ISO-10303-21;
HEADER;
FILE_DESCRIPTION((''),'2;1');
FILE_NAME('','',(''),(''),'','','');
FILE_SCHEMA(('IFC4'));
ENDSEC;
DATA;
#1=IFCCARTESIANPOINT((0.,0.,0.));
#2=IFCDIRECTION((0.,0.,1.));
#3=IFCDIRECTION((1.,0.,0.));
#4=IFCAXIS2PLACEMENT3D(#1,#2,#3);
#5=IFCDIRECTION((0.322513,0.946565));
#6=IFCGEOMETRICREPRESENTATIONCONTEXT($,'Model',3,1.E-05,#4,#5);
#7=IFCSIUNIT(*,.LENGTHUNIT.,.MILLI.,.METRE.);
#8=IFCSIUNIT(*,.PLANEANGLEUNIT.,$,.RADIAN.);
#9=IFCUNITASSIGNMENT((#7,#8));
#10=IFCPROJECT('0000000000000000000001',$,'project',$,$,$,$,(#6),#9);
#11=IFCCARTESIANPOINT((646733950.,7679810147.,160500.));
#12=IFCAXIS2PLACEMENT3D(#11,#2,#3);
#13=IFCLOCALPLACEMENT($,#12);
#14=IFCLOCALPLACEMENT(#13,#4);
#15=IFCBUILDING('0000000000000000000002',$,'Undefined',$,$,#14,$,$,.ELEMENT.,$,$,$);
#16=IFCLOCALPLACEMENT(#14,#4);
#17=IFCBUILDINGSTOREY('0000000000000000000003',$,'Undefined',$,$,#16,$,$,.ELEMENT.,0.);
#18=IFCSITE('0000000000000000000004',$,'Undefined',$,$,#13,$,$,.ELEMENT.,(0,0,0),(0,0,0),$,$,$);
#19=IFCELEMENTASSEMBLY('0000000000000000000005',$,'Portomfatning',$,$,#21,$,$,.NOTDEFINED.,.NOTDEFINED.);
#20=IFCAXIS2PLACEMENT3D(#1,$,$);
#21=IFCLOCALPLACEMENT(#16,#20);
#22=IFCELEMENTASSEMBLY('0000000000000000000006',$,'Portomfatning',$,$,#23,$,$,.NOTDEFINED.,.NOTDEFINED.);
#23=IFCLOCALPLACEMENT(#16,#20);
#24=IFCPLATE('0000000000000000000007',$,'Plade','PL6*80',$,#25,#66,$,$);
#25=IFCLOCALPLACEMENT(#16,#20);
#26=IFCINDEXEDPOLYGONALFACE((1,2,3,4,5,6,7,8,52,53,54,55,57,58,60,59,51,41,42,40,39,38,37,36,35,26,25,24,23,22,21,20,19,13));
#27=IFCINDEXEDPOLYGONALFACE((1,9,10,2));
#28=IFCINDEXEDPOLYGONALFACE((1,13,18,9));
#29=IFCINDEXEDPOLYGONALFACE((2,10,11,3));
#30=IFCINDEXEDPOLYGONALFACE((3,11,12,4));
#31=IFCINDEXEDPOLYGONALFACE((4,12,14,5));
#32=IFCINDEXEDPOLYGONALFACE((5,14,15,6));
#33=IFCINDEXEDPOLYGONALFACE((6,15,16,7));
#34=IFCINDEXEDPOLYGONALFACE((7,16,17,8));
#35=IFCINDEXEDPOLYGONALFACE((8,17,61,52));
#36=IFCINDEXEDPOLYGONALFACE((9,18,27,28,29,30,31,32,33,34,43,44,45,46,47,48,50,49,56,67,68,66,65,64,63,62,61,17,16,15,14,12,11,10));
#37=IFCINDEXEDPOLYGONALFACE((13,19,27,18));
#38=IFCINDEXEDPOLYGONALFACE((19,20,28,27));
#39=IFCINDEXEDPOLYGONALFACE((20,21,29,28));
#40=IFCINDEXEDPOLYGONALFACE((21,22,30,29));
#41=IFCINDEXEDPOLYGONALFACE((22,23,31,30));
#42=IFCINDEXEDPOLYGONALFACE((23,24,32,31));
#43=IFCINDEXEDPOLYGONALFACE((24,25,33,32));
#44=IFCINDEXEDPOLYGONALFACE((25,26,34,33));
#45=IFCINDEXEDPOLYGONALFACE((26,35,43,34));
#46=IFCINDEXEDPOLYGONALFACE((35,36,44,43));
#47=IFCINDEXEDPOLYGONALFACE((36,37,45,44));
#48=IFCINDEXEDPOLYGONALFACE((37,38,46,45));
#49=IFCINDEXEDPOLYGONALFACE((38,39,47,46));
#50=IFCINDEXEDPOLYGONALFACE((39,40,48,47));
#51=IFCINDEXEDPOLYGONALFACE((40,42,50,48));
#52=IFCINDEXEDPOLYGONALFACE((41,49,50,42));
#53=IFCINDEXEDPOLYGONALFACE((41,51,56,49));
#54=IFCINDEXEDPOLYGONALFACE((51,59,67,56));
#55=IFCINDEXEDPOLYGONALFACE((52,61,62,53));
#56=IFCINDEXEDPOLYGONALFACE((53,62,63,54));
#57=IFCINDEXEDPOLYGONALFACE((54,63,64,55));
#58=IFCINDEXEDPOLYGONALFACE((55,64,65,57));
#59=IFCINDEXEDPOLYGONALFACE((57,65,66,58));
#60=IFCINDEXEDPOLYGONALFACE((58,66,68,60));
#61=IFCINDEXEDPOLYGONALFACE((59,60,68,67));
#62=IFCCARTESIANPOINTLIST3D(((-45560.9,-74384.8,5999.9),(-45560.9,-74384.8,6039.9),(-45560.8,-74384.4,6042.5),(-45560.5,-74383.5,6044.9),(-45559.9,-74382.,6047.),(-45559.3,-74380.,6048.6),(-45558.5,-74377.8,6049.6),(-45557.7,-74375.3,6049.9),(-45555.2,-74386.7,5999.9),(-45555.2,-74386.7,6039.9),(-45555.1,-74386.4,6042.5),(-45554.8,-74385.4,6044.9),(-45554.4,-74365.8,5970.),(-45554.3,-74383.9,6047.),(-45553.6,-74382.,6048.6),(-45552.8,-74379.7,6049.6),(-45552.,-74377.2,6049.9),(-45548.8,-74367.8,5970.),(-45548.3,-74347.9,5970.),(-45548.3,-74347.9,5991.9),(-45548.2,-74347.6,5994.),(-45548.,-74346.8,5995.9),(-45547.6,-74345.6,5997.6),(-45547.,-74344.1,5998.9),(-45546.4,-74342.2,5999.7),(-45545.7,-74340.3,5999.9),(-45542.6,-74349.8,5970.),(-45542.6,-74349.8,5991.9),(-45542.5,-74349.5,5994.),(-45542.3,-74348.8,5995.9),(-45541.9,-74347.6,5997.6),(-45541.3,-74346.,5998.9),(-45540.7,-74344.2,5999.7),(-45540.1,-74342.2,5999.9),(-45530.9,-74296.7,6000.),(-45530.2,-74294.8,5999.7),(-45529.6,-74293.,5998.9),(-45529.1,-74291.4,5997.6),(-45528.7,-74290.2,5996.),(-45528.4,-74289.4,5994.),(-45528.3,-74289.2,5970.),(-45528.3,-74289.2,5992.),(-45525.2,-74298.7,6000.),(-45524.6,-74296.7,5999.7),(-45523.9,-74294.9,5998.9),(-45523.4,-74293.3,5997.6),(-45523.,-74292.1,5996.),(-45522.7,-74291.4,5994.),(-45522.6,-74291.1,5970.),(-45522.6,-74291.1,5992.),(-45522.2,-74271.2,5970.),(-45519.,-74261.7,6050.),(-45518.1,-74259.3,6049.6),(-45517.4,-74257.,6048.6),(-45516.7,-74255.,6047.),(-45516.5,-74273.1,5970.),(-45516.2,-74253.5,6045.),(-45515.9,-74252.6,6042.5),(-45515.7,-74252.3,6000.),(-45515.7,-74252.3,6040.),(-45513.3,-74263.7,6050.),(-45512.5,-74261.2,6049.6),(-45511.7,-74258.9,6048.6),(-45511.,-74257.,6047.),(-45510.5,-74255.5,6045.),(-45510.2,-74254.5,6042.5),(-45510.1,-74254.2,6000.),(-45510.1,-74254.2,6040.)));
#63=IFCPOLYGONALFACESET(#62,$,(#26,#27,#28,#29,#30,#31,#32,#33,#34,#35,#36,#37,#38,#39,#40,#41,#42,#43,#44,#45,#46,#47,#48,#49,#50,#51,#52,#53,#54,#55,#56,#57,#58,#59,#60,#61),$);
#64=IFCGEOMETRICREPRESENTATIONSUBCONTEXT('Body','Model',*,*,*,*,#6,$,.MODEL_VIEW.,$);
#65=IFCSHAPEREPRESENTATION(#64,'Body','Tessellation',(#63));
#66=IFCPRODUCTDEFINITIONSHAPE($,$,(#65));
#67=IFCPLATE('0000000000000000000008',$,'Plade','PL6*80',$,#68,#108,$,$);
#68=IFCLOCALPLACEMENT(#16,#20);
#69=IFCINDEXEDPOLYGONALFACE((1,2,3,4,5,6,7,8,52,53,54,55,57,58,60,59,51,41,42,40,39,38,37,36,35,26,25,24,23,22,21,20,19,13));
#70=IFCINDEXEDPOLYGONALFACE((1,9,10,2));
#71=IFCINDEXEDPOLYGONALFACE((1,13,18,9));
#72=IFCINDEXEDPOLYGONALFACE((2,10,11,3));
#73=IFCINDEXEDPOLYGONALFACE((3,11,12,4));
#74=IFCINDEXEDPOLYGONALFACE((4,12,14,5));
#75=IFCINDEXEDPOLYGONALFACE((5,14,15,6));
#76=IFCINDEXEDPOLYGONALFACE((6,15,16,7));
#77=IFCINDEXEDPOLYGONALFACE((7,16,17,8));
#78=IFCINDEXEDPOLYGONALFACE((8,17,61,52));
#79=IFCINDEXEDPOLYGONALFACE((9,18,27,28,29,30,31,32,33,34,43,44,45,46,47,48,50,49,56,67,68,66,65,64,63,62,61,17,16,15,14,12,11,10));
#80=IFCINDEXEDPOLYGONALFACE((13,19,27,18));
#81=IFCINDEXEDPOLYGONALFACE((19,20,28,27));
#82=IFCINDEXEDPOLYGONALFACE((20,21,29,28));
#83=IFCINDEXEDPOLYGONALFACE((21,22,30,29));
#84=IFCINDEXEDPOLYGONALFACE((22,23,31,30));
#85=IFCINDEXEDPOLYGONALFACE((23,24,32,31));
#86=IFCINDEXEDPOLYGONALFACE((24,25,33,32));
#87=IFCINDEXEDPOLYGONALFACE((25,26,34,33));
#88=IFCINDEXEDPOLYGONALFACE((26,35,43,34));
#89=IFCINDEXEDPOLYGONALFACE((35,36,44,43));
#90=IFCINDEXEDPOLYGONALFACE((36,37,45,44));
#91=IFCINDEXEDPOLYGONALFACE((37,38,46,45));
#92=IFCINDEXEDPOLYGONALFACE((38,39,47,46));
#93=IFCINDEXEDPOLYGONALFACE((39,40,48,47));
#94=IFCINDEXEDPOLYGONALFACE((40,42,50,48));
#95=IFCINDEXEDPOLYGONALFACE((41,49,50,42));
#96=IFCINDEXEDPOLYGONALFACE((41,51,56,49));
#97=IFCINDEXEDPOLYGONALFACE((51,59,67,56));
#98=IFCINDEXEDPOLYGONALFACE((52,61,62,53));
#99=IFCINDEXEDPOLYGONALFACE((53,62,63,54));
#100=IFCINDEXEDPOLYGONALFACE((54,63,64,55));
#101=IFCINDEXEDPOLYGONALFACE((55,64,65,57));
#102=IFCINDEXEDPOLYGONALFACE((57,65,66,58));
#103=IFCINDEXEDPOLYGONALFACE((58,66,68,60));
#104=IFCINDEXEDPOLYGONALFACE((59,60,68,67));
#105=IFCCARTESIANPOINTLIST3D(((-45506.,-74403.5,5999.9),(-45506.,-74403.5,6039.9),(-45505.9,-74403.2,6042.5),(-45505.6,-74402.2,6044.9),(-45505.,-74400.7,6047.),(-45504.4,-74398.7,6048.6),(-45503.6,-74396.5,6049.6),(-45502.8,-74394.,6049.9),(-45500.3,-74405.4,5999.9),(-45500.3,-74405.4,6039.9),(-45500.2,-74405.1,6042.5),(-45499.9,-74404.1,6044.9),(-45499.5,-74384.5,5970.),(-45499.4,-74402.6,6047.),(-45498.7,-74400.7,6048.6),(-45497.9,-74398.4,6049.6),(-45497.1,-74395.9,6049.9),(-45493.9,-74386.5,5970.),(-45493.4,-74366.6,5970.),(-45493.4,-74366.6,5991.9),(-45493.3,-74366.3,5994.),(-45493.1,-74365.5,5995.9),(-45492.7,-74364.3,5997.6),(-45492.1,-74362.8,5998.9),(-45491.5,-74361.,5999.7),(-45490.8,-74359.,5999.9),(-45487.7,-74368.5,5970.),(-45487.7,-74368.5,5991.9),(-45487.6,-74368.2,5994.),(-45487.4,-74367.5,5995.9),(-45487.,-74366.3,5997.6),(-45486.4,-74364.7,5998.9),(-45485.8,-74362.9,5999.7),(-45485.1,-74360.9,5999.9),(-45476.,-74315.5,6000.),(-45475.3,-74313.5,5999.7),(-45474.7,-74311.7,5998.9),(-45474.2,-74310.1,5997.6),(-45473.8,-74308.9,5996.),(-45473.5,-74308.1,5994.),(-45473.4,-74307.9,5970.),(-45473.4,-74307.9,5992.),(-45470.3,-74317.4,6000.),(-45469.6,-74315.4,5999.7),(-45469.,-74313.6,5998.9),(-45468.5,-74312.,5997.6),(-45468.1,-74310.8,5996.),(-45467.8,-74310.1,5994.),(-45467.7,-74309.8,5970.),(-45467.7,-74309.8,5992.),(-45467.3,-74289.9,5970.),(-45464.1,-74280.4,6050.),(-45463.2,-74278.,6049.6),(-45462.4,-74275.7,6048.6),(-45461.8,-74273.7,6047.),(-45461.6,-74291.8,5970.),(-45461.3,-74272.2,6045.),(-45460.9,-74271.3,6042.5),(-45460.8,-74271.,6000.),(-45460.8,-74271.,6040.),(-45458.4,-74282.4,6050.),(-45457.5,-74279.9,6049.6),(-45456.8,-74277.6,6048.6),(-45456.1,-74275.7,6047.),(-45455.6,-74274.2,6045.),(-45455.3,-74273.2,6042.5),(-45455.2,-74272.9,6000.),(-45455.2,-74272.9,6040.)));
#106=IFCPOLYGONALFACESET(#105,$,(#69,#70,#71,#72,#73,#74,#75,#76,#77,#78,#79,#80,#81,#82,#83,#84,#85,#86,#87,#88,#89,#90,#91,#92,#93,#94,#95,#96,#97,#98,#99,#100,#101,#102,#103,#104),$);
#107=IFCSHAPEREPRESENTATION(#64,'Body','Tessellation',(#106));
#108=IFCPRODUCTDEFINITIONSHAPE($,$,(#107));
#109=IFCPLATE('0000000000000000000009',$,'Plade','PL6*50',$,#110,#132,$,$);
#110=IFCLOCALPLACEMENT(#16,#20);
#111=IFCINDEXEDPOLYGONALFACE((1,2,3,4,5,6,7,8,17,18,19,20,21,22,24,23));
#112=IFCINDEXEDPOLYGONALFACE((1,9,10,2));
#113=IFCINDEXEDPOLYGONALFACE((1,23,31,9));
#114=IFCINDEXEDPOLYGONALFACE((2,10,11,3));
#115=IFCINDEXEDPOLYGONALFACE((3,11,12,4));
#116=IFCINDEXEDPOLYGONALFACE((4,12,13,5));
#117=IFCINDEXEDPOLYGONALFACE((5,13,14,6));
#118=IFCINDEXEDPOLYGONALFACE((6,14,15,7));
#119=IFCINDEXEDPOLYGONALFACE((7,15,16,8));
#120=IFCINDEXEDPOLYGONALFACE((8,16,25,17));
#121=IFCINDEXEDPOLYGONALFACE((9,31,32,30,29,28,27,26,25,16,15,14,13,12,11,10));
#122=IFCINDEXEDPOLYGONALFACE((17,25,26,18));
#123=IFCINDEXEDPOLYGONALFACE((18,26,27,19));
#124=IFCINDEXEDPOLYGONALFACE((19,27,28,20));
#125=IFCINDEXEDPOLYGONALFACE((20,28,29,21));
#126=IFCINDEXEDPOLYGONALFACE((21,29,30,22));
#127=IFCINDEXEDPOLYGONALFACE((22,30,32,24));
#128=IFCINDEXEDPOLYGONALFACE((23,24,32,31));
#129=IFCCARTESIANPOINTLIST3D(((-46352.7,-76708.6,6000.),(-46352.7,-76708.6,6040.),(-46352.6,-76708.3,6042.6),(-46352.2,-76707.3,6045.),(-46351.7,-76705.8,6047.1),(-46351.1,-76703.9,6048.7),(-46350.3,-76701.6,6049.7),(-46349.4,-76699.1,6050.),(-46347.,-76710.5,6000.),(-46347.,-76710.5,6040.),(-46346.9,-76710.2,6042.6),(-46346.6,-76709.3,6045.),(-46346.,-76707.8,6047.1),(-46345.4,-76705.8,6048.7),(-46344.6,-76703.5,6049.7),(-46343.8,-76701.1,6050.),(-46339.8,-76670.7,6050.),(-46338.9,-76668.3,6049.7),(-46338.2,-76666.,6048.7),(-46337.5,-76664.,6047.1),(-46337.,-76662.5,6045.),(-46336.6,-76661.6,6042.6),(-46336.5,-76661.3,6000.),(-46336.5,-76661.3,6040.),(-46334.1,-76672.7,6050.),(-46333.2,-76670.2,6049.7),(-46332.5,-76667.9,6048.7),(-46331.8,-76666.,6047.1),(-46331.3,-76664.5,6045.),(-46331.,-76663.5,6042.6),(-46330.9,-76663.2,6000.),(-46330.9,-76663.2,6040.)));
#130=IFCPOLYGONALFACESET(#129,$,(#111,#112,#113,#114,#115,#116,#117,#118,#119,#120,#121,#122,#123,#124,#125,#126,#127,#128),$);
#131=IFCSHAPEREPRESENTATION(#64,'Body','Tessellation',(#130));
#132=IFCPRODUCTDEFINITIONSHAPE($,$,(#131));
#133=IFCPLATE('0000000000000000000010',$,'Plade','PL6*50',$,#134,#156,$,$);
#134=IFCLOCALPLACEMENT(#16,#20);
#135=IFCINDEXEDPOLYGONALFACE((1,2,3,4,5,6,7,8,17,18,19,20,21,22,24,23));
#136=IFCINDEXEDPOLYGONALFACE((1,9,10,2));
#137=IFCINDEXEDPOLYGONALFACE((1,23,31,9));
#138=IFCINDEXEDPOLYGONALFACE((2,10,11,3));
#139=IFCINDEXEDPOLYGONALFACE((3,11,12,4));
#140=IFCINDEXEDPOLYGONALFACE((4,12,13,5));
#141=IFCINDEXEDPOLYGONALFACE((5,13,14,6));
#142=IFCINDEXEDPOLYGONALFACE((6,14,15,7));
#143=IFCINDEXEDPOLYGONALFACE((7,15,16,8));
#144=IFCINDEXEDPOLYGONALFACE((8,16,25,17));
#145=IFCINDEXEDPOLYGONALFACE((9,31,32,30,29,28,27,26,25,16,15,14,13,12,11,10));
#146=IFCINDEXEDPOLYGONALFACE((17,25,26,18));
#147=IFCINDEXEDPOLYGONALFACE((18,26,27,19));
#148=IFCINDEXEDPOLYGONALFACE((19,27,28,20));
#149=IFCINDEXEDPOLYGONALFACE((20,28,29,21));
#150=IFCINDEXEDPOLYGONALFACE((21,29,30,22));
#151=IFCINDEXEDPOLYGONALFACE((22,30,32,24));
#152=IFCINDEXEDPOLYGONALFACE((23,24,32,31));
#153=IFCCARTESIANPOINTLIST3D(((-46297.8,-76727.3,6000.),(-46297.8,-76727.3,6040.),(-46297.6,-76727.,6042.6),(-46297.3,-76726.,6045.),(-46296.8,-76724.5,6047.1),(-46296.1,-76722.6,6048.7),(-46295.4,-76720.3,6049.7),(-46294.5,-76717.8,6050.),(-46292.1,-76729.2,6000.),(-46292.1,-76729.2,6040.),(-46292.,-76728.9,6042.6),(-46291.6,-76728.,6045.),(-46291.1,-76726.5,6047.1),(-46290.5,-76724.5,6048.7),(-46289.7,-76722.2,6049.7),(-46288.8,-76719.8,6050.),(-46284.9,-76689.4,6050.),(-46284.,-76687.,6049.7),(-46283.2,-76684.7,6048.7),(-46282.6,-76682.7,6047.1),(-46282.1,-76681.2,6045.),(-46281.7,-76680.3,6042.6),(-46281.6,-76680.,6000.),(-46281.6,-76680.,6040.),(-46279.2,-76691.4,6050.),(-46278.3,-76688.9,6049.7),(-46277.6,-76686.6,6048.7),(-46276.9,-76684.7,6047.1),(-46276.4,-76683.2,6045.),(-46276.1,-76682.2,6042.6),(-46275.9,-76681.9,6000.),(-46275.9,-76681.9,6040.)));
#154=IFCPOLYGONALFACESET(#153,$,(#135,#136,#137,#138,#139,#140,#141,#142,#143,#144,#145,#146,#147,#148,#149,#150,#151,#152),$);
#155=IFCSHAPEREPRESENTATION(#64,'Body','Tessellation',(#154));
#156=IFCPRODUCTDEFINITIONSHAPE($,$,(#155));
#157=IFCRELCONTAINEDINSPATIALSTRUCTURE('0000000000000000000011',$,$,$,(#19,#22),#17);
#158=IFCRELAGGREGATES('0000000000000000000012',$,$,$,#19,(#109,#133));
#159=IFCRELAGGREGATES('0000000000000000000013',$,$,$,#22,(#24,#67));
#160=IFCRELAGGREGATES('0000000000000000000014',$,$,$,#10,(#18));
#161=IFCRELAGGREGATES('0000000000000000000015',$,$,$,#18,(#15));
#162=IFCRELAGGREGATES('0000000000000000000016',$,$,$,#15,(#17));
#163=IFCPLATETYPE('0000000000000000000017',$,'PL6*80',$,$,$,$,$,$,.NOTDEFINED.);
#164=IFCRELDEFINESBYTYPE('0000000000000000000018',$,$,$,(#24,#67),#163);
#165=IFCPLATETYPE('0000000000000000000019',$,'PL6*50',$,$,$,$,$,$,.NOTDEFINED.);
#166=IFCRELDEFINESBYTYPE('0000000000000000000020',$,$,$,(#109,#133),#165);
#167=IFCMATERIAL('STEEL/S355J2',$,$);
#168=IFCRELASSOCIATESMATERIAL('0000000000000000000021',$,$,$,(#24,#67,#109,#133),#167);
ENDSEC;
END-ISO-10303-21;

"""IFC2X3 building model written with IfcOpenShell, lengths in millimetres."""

from ifc_helpers import new_model, si_unit, direction, frame, frame_2d, origin_with_axes, place, context, subcontext, project, spatial, polyline, circle_curve, parameter, trimmed, segment, composite_curve, outline, extrude, material, type_object, element, aggregate, save


model = new_model("IFC2X3")

# Units and contexts
model_context = context("Model", 3, precision=1e-05, world=origin_with_axes(), true_north=direction((0.322513, 0.946565)))
body_context = subcontext(model_context, "Body", "Model", "MODEL_VIEW")
ifc_project = project(units=[si_unit("LENGTHUNIT", "METRE", prefix="MILLI"), si_unit("PLANEANGLEUNIT", "RADIAN")], contexts=[model_context])

# Site, building, storey
site_placement = place(None, frame((646733950.0, 7679810147.0, 160500.0), z_axis=(0.0, 0.0, 1.0), x_axis=(1.0, 0.0, 0.0)))
site = spatial("IfcSite", under=ifc_project, at=site_placement, Name="Undefined", CompositionType="ELEMENT", RefLatitude=(0, 0, 0), RefLongitude=(0, 0, 0))
building_placement = place(site_placement, origin_with_axes())
building = spatial("IfcBuilding", under=site, at=building_placement, Name="Undefined", CompositionType="ELEMENT")
storey_placement = place(building_placement, origin_with_axes())
storey = spatial("IfcBuildingStorey", under=building, at=storey_placement, Name="Undefined", CompositionType="ELEMENT", Elevation=0.0)

# Element assembly
assembly_1_placement = place(storey_placement, origin_with_axes())
assembly_1 = element("IfcElementAssembly", 1, at=assembly_1_placement, inside=storey, Name="Portomfatning", AssemblyPlace="NOTDEFINED", PredefinedType="NOTDEFINED")

# Shared definitions
ifc_material_1 = material(Name="STEEL/S355J2")

# Element assembly
assembly_2_placement = place(storey_placement, origin_with_axes())
assembly_2 = element("IfcElementAssembly", 2, at=assembly_2_placement, inside=storey, Name="Portomfatning", AssemblyPlace="NOTDEFINED", PredefinedType="NOTDEFINED")

# Plates
plate_type_1 = type_object("IfcPlateType", Name="PL6*80", PredefinedType="NOTDEFINED")
plate_1_placement = place(assembly_2_placement, frame((-45558.1, -74385.7, 6049.9), z_axis=(0.946565, -0.322513, 0.0), x_axis=(0.0, 0.0, -1.0)))
plate_1 = element("IfcPlate", 3, at=plate_1_placement, type_object=plate_type_1, material=ifc_material_1, Name="Plade", Description="PL6*80", context=body_context, shape_type="SweptSolid", body=[
    extrude(outline(composite_curve([segment(trimmed(circle_curve(frame_2d((10.0, 10.0), x_axis=(-1.0, -0.000007)), 10.0), [parameter(0.0)], [parameter(1.570789)], True, "PARAMETER"), True, "CONTINUOUS"), segment(polyline([(10.0, 0.0), (50.0, 0.0), (80.0, 20.0), (80.0, 39.0), (58.0, 39.0)]), True, "CONTINUOUS"), segment(trimmed(circle_curve(frame_2d((58.0, 47.0), x_axis=(0.000062, -1.0)), 8.0), [parameter(0.0)], [parameter(4.712337)], False, "PARAMETER"), True, "CONTINUOUS"), segment(polyline([(50.0, 47.0), (50.0, 93.0)]), True, "CONTINUOUS"), segment(trimmed(circle_curve(frame_2d((58.0, 93.0), x_axis=(-1.0, -0.00001)), 8.0), [parameter(0.0)], [parameter(4.712441)], False, "PARAMETER"), True, "CONTINUOUS"), segment(polyline([(58.0, 101.0), (80.0, 101.0), (80.0, 120.0), (50.0, 140.0), (10.0, 140.0)]), True, "CONTINUOUS"), segment(trimmed(circle_curve(frame_2d((10.0, 130.0), x_axis=(0.0, 1.0)), 10.0), [parameter(0.0)], [parameter(1.570803)], True, "PARAMETER"), True, "CONTINUOUS"), segment(polyline([(0.0, 130.0), (0.0, 10.0)]), True, "CONTINUOUS")], self_intersect=True)), frame((0.0, 0.0, -3.0), z_axis=(0.0, 0.0, 1.0), x_axis=(1.0, 0.0, 0.0)), (0.0, 0.0, 1.0), 6.0),
])
plate_2_placement = place(assembly_2_placement, frame((-45503.1, -74404.4, 6049.9), z_axis=(0.946565, -0.322513, 0.0), x_axis=(0.0, 0.0, -1.0)))
plate_2 = element("IfcPlate", 4, at=plate_2_placement, type_object=plate_type_1, material=ifc_material_1, Name="Plade", Description="PL6*80", context=body_context, shape_type="SweptSolid", body=[
    extrude(outline(composite_curve([segment(trimmed(circle_curve(frame_2d((10.0, 10.0), x_axis=(-1.0, -0.000007)), 10.0), [parameter(0.0)], [parameter(1.570789)], True, "PARAMETER"), True, "CONTINUOUS"), segment(polyline([(10.0, 0.0), (50.0, 0.0), (80.0, 20.0), (80.0, 39.0), (58.0, 39.0)]), True, "CONTINUOUS"), segment(trimmed(circle_curve(frame_2d((58.0, 47.0), x_axis=(0.000053, -1.0)), 8.0), [parameter(0.0)], [parameter(4.712346)], False, "PARAMETER"), True, "CONTINUOUS"), segment(polyline([(50.0, 47.0), (50.0, 93.0)]), True, "CONTINUOUS"), segment(trimmed(circle_curve(frame_2d((58.0, 93.0), x_axis=(-1.0, -0.00001)), 8.0), [parameter(0.0)], [parameter(4.712421)], False, "PARAMETER"), True, "CONTINUOUS"), segment(polyline([(58.0, 101.0), (80.0, 101.0), (80.0, 120.0), (50.0, 140.0), (10.0, 140.0)]), True, "CONTINUOUS"), segment(trimmed(circle_curve(frame_2d((10.0, 130.0), x_axis=(0.0, 1.0)), 10.0), [parameter(0.0)], [parameter(1.570803)], True, "PARAMETER"), True, "CONTINUOUS"), segment(polyline([(0.0, 130.0), (0.0, 10.0)]), True, "CONTINUOUS")], self_intersect=True)), frame((0.0, 0.0, -3.0), z_axis=(0.0, 0.0, 1.0), x_axis=(1.0, 0.0, 0.0)), (0.0, 0.0, 1.0), 6.0),
])
plate_type_2 = type_object("IfcPlateType", Name="PL6*50", PredefinedType="NOTDEFINED")
plate_3_placement = place(assembly_1_placement, frame((-46349.8, -76709.6, 6050.0), z_axis=(0.946565, -0.322513, 0.0), x_axis=(0.0, 0.0, -1.0)))
plate_3 = element("IfcPlate", 5, at=plate_3_placement, type_object=plate_type_2, material=ifc_material_1, Name="Plade", Description="PL6*50", context=body_context, shape_type="SweptSolid", body=[
    extrude(outline(composite_curve([segment(trimmed(circle_curve(frame_2d((10.0, 10.0), x_axis=(-1.0, -0.000002)), 10.0), [parameter(0.0)], [parameter(1.570794)], True, "PARAMETER"), True, "CONTINUOUS"), segment(polyline([(10.0, 0.0), (50.0, 0.0), (50.0, 50.0), (10.0, 50.0)]), True, "CONTINUOUS"), segment(trimmed(circle_curve(frame_2d((10.0, 40.0), x_axis=(0.0, 1.0)), 10.0), [parameter(0.0)], [parameter(1.570798)], True, "PARAMETER"), True, "CONTINUOUS"), segment(polyline([(0.0, 40.0), (0.0, 10.0)]), True, "CONTINUOUS")], self_intersect=True)), frame((0.0, 0.0, -3.0), z_axis=(0.0, 0.0, 1.0), x_axis=(1.0, 0.0, 0.0)), (0.0, 0.0, 1.0), 6.0),
])
plate_4_placement = place(assembly_1_placement, frame((-46294.9, -76728.3, 6050.0), z_axis=(0.946565, -0.322513, 0.0), x_axis=(0.0, 0.0, -1.0)))
plate_4 = element("IfcPlate", 6, at=plate_4_placement, type_object=plate_type_2, material=ifc_material_1, Name="Plade", Description="PL6*50", context=body_context, shape_type="SweptSolid", body=[
    extrude(outline(composite_curve([segment(trimmed(circle_curve(frame_2d((10.0, 10.0), x_axis=(-1.0, -0.000002)), 10.0), [parameter(0.0)], [parameter(1.570794)], True, "PARAMETER"), True, "CONTINUOUS"), segment(polyline([(10.0, 0.0), (50.0, 0.0), (50.0, 50.0), (10.0, 50.0)]), True, "CONTINUOUS"), segment(trimmed(circle_curve(frame_2d((10.0, 40.0), x_axis=(0.0, 1.0)), 10.0), [parameter(0.0)], [parameter(1.570798)], True, "PARAMETER"), True, "CONTINUOUS"), segment(polyline([(0.0, 40.0), (0.0, 10.0)]), True, "CONTINUOUS")], self_intersect=True)), frame((0.0, 0.0, -3.0), z_axis=(0.0, 0.0, 1.0), x_axis=(1.0, 0.0, 0.0)), (0.0, 0.0, 1.0), 6.0),
])

aggregate(assembly_1, [plate_3, plate_4])
aggregate(assembly_2, [plate_1, plate_2])

save(model, "model.ifc")
